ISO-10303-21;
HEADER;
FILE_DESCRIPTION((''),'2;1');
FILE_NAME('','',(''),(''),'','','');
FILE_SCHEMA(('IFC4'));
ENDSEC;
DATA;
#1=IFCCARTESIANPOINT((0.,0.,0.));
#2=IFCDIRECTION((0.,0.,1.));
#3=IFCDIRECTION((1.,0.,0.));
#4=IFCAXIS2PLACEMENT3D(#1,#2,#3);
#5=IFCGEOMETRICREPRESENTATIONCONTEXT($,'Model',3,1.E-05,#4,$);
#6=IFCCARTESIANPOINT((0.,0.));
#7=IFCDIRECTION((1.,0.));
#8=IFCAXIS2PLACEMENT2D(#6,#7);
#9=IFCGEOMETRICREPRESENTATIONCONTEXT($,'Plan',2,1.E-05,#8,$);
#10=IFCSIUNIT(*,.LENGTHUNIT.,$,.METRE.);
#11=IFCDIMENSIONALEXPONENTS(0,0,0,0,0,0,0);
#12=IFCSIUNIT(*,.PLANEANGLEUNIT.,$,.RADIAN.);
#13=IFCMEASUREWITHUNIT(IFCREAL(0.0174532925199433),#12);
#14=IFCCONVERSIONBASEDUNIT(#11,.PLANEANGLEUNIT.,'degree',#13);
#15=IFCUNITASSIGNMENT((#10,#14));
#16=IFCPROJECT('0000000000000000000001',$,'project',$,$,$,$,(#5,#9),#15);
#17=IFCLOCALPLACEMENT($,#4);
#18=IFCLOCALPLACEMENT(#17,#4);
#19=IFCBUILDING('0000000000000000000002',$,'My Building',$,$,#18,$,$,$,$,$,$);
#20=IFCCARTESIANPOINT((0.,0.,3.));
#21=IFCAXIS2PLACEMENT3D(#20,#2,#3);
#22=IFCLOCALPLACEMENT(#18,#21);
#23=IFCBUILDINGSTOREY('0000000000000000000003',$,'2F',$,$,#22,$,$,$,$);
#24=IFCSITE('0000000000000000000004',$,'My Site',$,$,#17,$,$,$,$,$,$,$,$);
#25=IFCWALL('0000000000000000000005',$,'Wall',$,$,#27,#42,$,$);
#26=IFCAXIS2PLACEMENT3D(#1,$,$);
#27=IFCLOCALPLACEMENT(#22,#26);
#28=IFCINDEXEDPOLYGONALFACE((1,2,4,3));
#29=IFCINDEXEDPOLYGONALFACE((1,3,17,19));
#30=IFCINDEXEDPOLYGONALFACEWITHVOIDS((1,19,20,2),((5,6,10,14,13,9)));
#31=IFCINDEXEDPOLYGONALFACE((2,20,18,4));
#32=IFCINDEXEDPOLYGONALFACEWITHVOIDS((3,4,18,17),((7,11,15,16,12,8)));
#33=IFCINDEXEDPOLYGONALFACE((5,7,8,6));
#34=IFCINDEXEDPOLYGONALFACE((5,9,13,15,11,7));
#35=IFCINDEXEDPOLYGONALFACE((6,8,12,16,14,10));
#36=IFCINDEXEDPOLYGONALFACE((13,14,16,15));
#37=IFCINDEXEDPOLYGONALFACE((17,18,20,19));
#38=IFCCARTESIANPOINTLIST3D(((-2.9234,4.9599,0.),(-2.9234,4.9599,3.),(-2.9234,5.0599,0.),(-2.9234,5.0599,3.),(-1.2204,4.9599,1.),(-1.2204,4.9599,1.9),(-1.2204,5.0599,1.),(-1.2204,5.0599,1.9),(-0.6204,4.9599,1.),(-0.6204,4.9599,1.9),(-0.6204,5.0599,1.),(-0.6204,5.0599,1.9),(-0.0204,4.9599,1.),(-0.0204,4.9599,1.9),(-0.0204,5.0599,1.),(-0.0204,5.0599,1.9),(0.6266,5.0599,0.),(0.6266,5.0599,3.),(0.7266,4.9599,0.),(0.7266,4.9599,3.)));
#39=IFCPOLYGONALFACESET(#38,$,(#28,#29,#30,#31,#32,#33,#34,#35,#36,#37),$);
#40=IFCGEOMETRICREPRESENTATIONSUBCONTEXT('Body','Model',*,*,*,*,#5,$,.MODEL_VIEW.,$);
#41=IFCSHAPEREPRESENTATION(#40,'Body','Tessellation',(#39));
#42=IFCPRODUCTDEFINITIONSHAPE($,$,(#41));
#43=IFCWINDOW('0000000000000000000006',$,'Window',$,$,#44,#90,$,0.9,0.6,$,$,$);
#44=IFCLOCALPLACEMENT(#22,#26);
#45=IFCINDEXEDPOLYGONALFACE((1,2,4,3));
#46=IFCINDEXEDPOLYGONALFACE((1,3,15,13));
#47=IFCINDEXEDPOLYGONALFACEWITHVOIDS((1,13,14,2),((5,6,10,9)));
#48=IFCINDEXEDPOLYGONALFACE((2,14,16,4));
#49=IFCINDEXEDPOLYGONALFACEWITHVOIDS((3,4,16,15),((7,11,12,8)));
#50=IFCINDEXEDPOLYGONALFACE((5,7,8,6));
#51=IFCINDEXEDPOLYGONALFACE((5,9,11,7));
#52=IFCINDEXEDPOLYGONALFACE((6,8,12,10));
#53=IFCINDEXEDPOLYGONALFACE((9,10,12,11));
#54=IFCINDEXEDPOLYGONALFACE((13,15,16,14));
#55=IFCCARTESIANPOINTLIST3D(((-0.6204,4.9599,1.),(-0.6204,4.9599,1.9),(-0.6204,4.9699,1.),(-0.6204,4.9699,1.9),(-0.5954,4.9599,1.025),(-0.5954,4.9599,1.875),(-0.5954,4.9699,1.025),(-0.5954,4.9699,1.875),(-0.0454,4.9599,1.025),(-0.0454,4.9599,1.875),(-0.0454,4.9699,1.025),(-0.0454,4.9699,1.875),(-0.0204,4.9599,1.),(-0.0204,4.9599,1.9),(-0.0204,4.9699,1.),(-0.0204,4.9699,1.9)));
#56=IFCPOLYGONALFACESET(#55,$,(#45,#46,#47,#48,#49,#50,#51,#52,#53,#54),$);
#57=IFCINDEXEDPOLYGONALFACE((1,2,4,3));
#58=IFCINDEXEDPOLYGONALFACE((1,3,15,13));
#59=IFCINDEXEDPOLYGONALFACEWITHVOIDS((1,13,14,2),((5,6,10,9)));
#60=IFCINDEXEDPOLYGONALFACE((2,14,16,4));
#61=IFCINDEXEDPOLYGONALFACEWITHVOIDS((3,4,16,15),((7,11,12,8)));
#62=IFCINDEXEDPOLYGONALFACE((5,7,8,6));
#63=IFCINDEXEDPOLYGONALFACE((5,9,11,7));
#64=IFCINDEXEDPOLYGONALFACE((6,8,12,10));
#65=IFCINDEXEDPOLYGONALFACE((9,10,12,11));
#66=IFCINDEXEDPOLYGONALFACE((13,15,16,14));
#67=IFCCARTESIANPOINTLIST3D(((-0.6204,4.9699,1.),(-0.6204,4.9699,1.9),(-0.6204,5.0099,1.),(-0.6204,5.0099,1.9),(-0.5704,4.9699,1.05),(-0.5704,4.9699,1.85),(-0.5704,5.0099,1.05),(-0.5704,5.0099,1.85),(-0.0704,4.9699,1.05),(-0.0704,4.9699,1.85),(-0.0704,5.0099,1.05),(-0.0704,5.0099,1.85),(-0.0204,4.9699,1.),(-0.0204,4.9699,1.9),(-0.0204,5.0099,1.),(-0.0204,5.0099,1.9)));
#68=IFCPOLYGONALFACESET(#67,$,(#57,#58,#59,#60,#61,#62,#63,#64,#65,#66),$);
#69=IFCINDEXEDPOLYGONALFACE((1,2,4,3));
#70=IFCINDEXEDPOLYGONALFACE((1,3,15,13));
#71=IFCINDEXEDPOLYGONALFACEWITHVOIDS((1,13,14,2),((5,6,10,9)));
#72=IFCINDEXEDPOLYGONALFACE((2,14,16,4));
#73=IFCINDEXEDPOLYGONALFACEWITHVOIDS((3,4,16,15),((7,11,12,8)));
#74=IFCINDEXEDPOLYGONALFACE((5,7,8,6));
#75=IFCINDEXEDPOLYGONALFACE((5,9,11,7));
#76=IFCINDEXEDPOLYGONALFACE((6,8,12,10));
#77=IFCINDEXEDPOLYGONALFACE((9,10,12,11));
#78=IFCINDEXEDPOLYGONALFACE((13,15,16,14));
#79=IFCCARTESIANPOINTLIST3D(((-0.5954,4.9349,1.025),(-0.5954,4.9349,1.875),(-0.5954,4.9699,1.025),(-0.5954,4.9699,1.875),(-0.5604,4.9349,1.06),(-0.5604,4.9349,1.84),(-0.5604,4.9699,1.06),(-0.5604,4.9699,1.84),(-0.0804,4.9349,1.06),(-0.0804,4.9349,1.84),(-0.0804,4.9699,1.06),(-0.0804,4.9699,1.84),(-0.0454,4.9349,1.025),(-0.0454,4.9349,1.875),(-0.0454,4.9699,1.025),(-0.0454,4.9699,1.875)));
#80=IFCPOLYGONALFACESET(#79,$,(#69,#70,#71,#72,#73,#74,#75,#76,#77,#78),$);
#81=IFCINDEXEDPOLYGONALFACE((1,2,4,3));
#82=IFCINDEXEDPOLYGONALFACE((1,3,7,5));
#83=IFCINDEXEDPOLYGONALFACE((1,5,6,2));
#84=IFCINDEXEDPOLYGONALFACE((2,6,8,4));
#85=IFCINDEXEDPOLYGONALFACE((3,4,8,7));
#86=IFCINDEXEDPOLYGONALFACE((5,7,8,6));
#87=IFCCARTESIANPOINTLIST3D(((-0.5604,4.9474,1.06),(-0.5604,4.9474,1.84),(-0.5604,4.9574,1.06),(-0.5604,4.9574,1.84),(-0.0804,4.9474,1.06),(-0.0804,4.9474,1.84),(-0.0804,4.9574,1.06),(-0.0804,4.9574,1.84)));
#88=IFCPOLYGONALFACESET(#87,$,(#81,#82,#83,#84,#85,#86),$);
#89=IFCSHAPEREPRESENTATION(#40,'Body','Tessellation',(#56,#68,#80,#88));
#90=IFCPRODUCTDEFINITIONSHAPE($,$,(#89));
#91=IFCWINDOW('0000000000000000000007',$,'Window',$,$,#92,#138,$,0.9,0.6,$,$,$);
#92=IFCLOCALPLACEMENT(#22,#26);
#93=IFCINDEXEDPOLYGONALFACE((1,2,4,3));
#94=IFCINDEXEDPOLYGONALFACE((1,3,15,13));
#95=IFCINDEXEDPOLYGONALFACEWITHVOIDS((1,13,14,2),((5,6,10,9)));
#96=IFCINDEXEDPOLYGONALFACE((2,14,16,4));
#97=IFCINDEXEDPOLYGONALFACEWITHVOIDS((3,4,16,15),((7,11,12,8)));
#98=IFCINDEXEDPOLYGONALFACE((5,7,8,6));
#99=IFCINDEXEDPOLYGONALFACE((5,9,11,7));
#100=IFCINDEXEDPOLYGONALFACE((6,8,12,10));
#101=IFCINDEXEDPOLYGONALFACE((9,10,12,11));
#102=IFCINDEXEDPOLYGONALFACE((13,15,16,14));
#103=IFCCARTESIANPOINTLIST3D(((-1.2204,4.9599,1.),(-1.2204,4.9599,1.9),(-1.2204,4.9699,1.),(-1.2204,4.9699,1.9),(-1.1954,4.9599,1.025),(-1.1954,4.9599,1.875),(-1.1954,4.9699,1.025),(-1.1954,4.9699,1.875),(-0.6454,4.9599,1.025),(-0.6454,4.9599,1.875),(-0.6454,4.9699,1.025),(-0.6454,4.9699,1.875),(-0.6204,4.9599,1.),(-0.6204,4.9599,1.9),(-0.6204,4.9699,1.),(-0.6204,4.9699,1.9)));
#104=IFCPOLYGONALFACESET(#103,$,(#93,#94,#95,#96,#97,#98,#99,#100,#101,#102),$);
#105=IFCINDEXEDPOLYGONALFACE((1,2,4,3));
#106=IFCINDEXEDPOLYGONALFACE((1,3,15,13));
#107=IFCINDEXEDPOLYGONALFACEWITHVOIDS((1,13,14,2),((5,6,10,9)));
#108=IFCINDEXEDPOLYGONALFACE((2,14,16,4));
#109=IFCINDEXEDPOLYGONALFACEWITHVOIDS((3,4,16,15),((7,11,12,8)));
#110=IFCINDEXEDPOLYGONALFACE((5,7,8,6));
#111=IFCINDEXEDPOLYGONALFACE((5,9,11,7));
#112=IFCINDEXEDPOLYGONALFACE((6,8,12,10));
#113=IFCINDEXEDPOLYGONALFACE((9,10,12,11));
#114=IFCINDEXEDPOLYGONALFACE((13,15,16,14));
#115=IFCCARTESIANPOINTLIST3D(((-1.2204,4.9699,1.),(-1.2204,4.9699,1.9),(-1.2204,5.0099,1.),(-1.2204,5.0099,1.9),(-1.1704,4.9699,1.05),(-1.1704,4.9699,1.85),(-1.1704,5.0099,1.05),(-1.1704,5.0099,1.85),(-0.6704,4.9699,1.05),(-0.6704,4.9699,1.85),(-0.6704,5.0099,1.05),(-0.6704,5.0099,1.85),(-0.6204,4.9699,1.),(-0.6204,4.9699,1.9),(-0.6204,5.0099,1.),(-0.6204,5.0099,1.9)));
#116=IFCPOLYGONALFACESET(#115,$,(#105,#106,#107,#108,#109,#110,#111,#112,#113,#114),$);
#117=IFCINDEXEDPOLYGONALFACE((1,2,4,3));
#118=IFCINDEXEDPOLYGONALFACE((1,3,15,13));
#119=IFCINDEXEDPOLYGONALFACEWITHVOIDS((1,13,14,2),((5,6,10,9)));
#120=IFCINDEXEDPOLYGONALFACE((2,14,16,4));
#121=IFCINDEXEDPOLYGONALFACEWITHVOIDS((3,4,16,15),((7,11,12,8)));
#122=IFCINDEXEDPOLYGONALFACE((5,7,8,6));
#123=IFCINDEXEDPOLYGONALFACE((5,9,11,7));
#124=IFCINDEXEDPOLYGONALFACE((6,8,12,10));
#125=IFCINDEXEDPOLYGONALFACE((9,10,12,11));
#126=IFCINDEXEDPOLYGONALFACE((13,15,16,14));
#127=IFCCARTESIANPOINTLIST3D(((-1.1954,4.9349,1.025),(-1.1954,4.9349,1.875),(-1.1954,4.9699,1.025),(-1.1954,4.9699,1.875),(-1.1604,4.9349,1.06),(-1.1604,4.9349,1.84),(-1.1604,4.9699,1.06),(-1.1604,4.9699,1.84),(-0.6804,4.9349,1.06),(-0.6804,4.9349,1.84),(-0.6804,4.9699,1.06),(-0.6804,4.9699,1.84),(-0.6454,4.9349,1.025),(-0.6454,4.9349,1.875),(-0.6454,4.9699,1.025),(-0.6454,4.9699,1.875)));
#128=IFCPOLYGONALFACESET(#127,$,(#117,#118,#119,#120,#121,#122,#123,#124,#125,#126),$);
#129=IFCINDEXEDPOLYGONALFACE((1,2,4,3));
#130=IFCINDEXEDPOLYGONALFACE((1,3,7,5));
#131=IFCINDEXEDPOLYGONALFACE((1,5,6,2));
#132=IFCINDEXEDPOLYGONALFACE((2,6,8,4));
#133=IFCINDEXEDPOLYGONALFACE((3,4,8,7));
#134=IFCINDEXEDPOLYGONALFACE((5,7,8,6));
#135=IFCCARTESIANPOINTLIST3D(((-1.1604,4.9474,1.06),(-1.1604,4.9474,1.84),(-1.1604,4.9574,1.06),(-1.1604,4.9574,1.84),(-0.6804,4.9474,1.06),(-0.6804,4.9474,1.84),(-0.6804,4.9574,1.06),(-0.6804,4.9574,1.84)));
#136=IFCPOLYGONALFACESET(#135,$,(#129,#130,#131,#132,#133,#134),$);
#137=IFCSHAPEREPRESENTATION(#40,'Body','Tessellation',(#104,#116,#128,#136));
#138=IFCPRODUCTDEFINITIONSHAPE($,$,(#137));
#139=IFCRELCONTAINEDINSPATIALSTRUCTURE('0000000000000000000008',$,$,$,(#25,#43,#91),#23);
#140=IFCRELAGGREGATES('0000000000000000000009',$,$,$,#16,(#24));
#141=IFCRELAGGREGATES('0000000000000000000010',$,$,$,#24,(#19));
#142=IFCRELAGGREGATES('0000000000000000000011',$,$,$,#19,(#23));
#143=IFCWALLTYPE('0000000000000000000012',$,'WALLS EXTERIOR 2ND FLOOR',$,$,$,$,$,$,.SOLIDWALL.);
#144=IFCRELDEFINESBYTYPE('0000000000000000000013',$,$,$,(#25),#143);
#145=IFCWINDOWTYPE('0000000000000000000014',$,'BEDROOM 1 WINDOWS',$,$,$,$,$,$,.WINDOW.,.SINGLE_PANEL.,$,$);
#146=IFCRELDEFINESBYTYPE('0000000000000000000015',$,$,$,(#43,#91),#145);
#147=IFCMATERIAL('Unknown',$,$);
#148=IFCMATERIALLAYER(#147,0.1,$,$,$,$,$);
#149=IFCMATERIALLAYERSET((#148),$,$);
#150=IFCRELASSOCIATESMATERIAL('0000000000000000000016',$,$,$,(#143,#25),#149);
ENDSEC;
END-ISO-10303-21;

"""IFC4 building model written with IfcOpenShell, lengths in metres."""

from ifc_helpers import new_model, entity, si_unit, converted_unit, frame, origin_with_axes, origin_2d_with_axis, place, context, subcontext, project, spatial, line, indexed_curve, outline, extrude, shape, source, transform, mapped, material, layer, layer_set, layer_usage, type_object, type_shapes, element, fill, save


model = new_model("IFC4")

# Units and contexts
model_context = context("Model", 3, precision=1e-05, world=origin_with_axes())
plan_context = context("Plan", 2, precision=1e-05, world=origin_2d_with_axis())
body_context_1 = subcontext(model_context, "Body", "Model", "MODEL_VIEW")
body_context_2 = subcontext(plan_context, "Body", "Plan", "PLAN_VIEW")
ifc_project = project(units=[si_unit("LENGTHUNIT", "METRE"), converted_unit("PLANEANGLEUNIT", "degree", entity("IfcReal", 0.0174532925199433), si_unit("PLANEANGLEUNIT", "RADIAN"), dimensions=[0, 0, 0, 0, 0, 0, 0])], contexts=[model_context, plan_context])

# Site, building, storey
site_placement = place(None, origin_with_axes())
site = spatial("IfcSite", under=ifc_project, at=site_placement, Name="My Site")
building_placement = place(site_placement, origin_with_axes())
building = spatial("IfcBuilding", under=site, at=building_placement, Name="My Building")
storey_placement = place(building_placement, frame((0.0, 0.0, 3.0), z_axis=(0.0, 0.0, 1.0), x_axis=(1.0, 0.0, 0.0)))
storey = spatial("IfcBuildingStorey", under=building, at=storey_placement, Name="2F")

# Shared definitions
ifc_material = material(Name="Unknown")

# Shared definitions
ifc_layer_1 = layer(ifc_material, 0.1)
ifc_layer_set_1 = layer_set([ifc_layer_1])
wall_type_1 = type_object("IfcWallType", Name="WALLS EXTERIOR 2ND FLOOR", PredefinedType="SOLIDWALL", material=ifc_layer_set_1)

# Wall, openings, windows
ifc_layer_usage_1 = layer_usage(ifc_layer_set_1, "AXIS2", "POSITIVE", 0.0)
wall_1_placement = place(storey_placement, frame((0.6266, 5.0599, 0.0), z_axis=(0.0, 0.0, 1.0), x_axis=(-1.0, 0.0, 0.0)))
wall_1 = element("IfcWall", 1, at=wall_1_placement, inside=storey, type_object=wall_type_1, material=ifc_layer_usage_1, Name="Wall", context=body_context_1, shape_type="SweptSolid", body=[
    extrude(outline(indexed_curve([(0.0, 0.0), (-0.1, 0.1), (3.55, 0.1), (3.55, 0.0)], segments=[line(1, 2, 3, 4, 1)])), origin_with_axes(), (0.0, 0.0, 1.0), 3.0),
])
shared_shape_1 = source(origin_with_axes(), body_context_1, "Body", "SweptSolid", [
    extrude(outline(indexed_curve([(0.0, 0.0), (0.6, 0.0), (0.6, 0.9), (0.0, 0.9)], segments=[line(1, 2, 3, 4, 1)])), frame((0.0, -0.6, 0.0), z_axis=(0.0, -1.0, 0.0), x_axis=(1.0, 0.0, 0.0)), (0.0, 0.0, -1.0), 1.2),
])
opening_1_placement = place(wall_1_placement, frame((0.647, 0.0, 1.0), z_axis=(0.0, 0.0, 1.0), x_axis=(1.0, 0.0, 0.0)))
opening_1 = element("IfcOpeningElement", 2, at=opening_1_placement, cuts=wall_1, PredefinedType="OPENING", context=body_context_1, shape_type="MappedRepresentation", body=[
    mapped(shared_shape_1, transform((0.0, 0.0, 0.0), x_axis=(1.0, 0.0, 0.0), y_axis=(0.0, 1.0, 0.0), z_axis=(0.0, 0.0, 1.0), scale=1.0)),
])
opening_2_placement = place(wall_1_placement, frame((1.247, 0.0, 1.0), z_axis=(0.0, 0.0, 1.0), x_axis=(1.0, 0.0, 0.0)))
opening_2 = element("IfcOpeningElement", 3, at=opening_2_placement, cuts=wall_1, PredefinedType="OPENING", context=body_context_1, shape_type="MappedRepresentation", body=[
    mapped(shared_shape_1, transform((0.0, 0.0, 0.0), x_axis=(1.0, 0.0, 0.0), y_axis=(0.0, 1.0, 0.0), z_axis=(0.0, 0.0, 1.0), scale=1.0)),
])
window_type_1 = type_object("IfcWindowType", Name="BEDROOM 1 WINDOWS", PartitioningType="SINGLE_PANEL", PredefinedType="WINDOW")
shared_shape_2 = source(origin_with_axes(), body_context_1, "Body", "SweptSolid", [
    extrude(outline(indexed_curve([(0.0, 0.0), (0.6, 0.0), (0.6, 0.9), (0.0, 0.9)], segments=[line(1, 2, 3, 4, 1)]), holes=[indexed_curve([(0.025, 0.025), (0.575, 0.025), (0.575, 0.875), (0.025, 0.875)], segments=[line(1, 2, 3, 4, 1)])]), frame((0.0, 0.09, 0.0), z_axis=(0.0, -1.0, 0.0), x_axis=(1.0, 0.0, 0.0)), (0.0, 0.0, -1.0), 0.01),
    extrude(outline(indexed_curve([(0.0, 0.0), (0.6, 0.0), (0.6, 0.9), (0.0, 0.9)], segments=[line(1, 2, 3, 4, 1)]), holes=[indexed_curve([(0.05, 0.05), (0.55, 0.05), (0.55, 0.85), (0.05, 0.85)], segments=[line(1, 2, 3, 4, 1)])]), frame((0.0, 0.05, 0.0), z_axis=(0.0, -1.0, 0.0), x_axis=(1.0, 0.0, 0.0)), (0.0, 0.0, -1.0), 0.04),
    extrude(outline(indexed_curve([(0.0, 0.0), (0.55, 0.0), (0.55, 0.85), (0.0, 0.85)], segments=[line(1, 2, 3, 4, 1)]), holes=[indexed_curve([(0.035, 0.035), (0.515, 0.035), (0.515, 0.815), (0.035, 0.815)], segments=[line(1, 2, 3, 4, 1)])]), frame((0.025, 0.09, 0.025), z_axis=(0.0, -1.0, 0.0), x_axis=(1.0, 0.0, 0.0)), (0.0, 0.0, -1.0), 0.035),
    extrude(outline(indexed_curve([(0.035, 0.035), (0.515, 0.035), (0.515, 0.815), (0.035, 0.815)], segments=[line(1, 2, 3, 4, 1)])), frame((0.025, 0.1025, 0.025), z_axis=(0.0, -1.0, 0.0), x_axis=(1.0, 0.0, 0.0)), (0.0, 0.0, -1.0), 0.01),
])
shared_shape_3 = source(origin_with_axes(), body_context_2, "Body", "Curve2D", [
    entity("IfcIndexedPolyCurve", entity("IfcCartesianPointList2D", [[0.05, 0.05], [0.55, 0.05]])),
    entity("IfcIndexedPolyCurve", entity("IfcCartesianPointList2D", [[0.0, 0.1], [0.025, 0.1], [0.025, 0.09], [0.05, 0.09], [0.05, 0.05], [0.0, 0.05]]), [entity("IfcLineIndex", [1, 2, 3, 4, 5, 6, 1])]),
    entity("IfcIndexedPolyCurve", entity("IfcCartesianPointList2D", [[0.6, 0.1], [0.575, 0.1], [0.575, 0.09], [0.55, 0.09], [0.55, 0.05], [0.6, 0.05]]), [entity("IfcLineIndex", [1, 2, 3, 4, 5, 6, 1])]),
    entity("IfcIndexedPolyCurve", entity("IfcCartesianPointList2D", [[0.025, 0.09], [0.06, 0.09], [0.06, 0.125], [0.025, 0.125]]), [entity("IfcLineIndex", [1, 2, 3, 4, 1])]),
    entity("IfcIndexedPolyCurve", entity("IfcCartesianPointList2D", [[0.575, 0.09], [0.54, 0.09], [0.54, 0.125], [0.575, 0.125]]), [entity("IfcLineIndex", [1, 2, 3, 4, 1])]),
    entity("IfcIndexedPolyCurve", entity("IfcCartesianPointList2D", [[0.06, 0.09], [0.54, 0.09]])),
    entity("IfcIndexedPolyCurve", entity("IfcCartesianPointList2D", [[0.06, 0.125], [0.54, 0.125]])),
    entity("IfcIndexedPolyCurve", entity("IfcCartesianPointList2D", [[0.06, 0.1075], [0.54, 0.1075]])),
])
type_shapes(window_type_1, [shared_shape_2, shared_shape_3])
window_1_placement = place(opening_1_placement, origin_with_axes())
window_1 = element("IfcWindow", 4, at=window_1_placement, inside=storey, type_object=window_type_1, Name="Window", OverallHeight=0.9, OverallWidth=0.6, shapes=[
    shape(body_context_1, "Body", "MappedRepresentation", [mapped(shared_shape_2, transform((0.0, 0.0, 0.0), x_axis=(1.0, 0.0, 0.0), y_axis=(0.0, 1.0, 0.0), z_axis=(0.0, 0.0, 1.0), scale=1.0))]),
    shape(body_context_2, "Body", "MappedRepresentation", [mapped(shared_shape_3, transform((0.0, 0.0, 0.0), x_axis=(1.0, 0.0, 0.0), y_axis=(0.0, 1.0, 0.0), z_axis=(0.0, 0.0, 1.0), scale=1.0))]),
])
fill(opening_1, window_1)
window_2_placement = place(opening_2_placement, frame((0.0, 0.0, 0.0), z_axis=(0.0, 0.0, 1.0), x_axis=(1.0, 0.0, 0.0)))
window_2 = element("IfcWindow", 5, at=window_2_placement, inside=storey, type_object=window_type_1, Name="Window", OverallHeight=0.9, OverallWidth=0.6, shapes=[
    shape(body_context_1, "Body", "MappedRepresentation", [mapped(shared_shape_2, transform((0.0, 0.0, 0.0), x_axis=(1.0, 0.0, 0.0), y_axis=(0.0, 1.0, 0.0), z_axis=(0.0, 0.0, 1.0), scale=1.0))]),
    shape(body_context_2, "Body", "MappedRepresentation", [mapped(shared_shape_3, transform((0.0, 0.0, 0.0), x_axis=(1.0, 0.0, 0.0), y_axis=(0.0, 1.0, 0.0), z_axis=(0.0, 0.0, 1.0), scale=1.0))]),
])
fill(opening_2, window_2)

save(model, "model.ifc")
